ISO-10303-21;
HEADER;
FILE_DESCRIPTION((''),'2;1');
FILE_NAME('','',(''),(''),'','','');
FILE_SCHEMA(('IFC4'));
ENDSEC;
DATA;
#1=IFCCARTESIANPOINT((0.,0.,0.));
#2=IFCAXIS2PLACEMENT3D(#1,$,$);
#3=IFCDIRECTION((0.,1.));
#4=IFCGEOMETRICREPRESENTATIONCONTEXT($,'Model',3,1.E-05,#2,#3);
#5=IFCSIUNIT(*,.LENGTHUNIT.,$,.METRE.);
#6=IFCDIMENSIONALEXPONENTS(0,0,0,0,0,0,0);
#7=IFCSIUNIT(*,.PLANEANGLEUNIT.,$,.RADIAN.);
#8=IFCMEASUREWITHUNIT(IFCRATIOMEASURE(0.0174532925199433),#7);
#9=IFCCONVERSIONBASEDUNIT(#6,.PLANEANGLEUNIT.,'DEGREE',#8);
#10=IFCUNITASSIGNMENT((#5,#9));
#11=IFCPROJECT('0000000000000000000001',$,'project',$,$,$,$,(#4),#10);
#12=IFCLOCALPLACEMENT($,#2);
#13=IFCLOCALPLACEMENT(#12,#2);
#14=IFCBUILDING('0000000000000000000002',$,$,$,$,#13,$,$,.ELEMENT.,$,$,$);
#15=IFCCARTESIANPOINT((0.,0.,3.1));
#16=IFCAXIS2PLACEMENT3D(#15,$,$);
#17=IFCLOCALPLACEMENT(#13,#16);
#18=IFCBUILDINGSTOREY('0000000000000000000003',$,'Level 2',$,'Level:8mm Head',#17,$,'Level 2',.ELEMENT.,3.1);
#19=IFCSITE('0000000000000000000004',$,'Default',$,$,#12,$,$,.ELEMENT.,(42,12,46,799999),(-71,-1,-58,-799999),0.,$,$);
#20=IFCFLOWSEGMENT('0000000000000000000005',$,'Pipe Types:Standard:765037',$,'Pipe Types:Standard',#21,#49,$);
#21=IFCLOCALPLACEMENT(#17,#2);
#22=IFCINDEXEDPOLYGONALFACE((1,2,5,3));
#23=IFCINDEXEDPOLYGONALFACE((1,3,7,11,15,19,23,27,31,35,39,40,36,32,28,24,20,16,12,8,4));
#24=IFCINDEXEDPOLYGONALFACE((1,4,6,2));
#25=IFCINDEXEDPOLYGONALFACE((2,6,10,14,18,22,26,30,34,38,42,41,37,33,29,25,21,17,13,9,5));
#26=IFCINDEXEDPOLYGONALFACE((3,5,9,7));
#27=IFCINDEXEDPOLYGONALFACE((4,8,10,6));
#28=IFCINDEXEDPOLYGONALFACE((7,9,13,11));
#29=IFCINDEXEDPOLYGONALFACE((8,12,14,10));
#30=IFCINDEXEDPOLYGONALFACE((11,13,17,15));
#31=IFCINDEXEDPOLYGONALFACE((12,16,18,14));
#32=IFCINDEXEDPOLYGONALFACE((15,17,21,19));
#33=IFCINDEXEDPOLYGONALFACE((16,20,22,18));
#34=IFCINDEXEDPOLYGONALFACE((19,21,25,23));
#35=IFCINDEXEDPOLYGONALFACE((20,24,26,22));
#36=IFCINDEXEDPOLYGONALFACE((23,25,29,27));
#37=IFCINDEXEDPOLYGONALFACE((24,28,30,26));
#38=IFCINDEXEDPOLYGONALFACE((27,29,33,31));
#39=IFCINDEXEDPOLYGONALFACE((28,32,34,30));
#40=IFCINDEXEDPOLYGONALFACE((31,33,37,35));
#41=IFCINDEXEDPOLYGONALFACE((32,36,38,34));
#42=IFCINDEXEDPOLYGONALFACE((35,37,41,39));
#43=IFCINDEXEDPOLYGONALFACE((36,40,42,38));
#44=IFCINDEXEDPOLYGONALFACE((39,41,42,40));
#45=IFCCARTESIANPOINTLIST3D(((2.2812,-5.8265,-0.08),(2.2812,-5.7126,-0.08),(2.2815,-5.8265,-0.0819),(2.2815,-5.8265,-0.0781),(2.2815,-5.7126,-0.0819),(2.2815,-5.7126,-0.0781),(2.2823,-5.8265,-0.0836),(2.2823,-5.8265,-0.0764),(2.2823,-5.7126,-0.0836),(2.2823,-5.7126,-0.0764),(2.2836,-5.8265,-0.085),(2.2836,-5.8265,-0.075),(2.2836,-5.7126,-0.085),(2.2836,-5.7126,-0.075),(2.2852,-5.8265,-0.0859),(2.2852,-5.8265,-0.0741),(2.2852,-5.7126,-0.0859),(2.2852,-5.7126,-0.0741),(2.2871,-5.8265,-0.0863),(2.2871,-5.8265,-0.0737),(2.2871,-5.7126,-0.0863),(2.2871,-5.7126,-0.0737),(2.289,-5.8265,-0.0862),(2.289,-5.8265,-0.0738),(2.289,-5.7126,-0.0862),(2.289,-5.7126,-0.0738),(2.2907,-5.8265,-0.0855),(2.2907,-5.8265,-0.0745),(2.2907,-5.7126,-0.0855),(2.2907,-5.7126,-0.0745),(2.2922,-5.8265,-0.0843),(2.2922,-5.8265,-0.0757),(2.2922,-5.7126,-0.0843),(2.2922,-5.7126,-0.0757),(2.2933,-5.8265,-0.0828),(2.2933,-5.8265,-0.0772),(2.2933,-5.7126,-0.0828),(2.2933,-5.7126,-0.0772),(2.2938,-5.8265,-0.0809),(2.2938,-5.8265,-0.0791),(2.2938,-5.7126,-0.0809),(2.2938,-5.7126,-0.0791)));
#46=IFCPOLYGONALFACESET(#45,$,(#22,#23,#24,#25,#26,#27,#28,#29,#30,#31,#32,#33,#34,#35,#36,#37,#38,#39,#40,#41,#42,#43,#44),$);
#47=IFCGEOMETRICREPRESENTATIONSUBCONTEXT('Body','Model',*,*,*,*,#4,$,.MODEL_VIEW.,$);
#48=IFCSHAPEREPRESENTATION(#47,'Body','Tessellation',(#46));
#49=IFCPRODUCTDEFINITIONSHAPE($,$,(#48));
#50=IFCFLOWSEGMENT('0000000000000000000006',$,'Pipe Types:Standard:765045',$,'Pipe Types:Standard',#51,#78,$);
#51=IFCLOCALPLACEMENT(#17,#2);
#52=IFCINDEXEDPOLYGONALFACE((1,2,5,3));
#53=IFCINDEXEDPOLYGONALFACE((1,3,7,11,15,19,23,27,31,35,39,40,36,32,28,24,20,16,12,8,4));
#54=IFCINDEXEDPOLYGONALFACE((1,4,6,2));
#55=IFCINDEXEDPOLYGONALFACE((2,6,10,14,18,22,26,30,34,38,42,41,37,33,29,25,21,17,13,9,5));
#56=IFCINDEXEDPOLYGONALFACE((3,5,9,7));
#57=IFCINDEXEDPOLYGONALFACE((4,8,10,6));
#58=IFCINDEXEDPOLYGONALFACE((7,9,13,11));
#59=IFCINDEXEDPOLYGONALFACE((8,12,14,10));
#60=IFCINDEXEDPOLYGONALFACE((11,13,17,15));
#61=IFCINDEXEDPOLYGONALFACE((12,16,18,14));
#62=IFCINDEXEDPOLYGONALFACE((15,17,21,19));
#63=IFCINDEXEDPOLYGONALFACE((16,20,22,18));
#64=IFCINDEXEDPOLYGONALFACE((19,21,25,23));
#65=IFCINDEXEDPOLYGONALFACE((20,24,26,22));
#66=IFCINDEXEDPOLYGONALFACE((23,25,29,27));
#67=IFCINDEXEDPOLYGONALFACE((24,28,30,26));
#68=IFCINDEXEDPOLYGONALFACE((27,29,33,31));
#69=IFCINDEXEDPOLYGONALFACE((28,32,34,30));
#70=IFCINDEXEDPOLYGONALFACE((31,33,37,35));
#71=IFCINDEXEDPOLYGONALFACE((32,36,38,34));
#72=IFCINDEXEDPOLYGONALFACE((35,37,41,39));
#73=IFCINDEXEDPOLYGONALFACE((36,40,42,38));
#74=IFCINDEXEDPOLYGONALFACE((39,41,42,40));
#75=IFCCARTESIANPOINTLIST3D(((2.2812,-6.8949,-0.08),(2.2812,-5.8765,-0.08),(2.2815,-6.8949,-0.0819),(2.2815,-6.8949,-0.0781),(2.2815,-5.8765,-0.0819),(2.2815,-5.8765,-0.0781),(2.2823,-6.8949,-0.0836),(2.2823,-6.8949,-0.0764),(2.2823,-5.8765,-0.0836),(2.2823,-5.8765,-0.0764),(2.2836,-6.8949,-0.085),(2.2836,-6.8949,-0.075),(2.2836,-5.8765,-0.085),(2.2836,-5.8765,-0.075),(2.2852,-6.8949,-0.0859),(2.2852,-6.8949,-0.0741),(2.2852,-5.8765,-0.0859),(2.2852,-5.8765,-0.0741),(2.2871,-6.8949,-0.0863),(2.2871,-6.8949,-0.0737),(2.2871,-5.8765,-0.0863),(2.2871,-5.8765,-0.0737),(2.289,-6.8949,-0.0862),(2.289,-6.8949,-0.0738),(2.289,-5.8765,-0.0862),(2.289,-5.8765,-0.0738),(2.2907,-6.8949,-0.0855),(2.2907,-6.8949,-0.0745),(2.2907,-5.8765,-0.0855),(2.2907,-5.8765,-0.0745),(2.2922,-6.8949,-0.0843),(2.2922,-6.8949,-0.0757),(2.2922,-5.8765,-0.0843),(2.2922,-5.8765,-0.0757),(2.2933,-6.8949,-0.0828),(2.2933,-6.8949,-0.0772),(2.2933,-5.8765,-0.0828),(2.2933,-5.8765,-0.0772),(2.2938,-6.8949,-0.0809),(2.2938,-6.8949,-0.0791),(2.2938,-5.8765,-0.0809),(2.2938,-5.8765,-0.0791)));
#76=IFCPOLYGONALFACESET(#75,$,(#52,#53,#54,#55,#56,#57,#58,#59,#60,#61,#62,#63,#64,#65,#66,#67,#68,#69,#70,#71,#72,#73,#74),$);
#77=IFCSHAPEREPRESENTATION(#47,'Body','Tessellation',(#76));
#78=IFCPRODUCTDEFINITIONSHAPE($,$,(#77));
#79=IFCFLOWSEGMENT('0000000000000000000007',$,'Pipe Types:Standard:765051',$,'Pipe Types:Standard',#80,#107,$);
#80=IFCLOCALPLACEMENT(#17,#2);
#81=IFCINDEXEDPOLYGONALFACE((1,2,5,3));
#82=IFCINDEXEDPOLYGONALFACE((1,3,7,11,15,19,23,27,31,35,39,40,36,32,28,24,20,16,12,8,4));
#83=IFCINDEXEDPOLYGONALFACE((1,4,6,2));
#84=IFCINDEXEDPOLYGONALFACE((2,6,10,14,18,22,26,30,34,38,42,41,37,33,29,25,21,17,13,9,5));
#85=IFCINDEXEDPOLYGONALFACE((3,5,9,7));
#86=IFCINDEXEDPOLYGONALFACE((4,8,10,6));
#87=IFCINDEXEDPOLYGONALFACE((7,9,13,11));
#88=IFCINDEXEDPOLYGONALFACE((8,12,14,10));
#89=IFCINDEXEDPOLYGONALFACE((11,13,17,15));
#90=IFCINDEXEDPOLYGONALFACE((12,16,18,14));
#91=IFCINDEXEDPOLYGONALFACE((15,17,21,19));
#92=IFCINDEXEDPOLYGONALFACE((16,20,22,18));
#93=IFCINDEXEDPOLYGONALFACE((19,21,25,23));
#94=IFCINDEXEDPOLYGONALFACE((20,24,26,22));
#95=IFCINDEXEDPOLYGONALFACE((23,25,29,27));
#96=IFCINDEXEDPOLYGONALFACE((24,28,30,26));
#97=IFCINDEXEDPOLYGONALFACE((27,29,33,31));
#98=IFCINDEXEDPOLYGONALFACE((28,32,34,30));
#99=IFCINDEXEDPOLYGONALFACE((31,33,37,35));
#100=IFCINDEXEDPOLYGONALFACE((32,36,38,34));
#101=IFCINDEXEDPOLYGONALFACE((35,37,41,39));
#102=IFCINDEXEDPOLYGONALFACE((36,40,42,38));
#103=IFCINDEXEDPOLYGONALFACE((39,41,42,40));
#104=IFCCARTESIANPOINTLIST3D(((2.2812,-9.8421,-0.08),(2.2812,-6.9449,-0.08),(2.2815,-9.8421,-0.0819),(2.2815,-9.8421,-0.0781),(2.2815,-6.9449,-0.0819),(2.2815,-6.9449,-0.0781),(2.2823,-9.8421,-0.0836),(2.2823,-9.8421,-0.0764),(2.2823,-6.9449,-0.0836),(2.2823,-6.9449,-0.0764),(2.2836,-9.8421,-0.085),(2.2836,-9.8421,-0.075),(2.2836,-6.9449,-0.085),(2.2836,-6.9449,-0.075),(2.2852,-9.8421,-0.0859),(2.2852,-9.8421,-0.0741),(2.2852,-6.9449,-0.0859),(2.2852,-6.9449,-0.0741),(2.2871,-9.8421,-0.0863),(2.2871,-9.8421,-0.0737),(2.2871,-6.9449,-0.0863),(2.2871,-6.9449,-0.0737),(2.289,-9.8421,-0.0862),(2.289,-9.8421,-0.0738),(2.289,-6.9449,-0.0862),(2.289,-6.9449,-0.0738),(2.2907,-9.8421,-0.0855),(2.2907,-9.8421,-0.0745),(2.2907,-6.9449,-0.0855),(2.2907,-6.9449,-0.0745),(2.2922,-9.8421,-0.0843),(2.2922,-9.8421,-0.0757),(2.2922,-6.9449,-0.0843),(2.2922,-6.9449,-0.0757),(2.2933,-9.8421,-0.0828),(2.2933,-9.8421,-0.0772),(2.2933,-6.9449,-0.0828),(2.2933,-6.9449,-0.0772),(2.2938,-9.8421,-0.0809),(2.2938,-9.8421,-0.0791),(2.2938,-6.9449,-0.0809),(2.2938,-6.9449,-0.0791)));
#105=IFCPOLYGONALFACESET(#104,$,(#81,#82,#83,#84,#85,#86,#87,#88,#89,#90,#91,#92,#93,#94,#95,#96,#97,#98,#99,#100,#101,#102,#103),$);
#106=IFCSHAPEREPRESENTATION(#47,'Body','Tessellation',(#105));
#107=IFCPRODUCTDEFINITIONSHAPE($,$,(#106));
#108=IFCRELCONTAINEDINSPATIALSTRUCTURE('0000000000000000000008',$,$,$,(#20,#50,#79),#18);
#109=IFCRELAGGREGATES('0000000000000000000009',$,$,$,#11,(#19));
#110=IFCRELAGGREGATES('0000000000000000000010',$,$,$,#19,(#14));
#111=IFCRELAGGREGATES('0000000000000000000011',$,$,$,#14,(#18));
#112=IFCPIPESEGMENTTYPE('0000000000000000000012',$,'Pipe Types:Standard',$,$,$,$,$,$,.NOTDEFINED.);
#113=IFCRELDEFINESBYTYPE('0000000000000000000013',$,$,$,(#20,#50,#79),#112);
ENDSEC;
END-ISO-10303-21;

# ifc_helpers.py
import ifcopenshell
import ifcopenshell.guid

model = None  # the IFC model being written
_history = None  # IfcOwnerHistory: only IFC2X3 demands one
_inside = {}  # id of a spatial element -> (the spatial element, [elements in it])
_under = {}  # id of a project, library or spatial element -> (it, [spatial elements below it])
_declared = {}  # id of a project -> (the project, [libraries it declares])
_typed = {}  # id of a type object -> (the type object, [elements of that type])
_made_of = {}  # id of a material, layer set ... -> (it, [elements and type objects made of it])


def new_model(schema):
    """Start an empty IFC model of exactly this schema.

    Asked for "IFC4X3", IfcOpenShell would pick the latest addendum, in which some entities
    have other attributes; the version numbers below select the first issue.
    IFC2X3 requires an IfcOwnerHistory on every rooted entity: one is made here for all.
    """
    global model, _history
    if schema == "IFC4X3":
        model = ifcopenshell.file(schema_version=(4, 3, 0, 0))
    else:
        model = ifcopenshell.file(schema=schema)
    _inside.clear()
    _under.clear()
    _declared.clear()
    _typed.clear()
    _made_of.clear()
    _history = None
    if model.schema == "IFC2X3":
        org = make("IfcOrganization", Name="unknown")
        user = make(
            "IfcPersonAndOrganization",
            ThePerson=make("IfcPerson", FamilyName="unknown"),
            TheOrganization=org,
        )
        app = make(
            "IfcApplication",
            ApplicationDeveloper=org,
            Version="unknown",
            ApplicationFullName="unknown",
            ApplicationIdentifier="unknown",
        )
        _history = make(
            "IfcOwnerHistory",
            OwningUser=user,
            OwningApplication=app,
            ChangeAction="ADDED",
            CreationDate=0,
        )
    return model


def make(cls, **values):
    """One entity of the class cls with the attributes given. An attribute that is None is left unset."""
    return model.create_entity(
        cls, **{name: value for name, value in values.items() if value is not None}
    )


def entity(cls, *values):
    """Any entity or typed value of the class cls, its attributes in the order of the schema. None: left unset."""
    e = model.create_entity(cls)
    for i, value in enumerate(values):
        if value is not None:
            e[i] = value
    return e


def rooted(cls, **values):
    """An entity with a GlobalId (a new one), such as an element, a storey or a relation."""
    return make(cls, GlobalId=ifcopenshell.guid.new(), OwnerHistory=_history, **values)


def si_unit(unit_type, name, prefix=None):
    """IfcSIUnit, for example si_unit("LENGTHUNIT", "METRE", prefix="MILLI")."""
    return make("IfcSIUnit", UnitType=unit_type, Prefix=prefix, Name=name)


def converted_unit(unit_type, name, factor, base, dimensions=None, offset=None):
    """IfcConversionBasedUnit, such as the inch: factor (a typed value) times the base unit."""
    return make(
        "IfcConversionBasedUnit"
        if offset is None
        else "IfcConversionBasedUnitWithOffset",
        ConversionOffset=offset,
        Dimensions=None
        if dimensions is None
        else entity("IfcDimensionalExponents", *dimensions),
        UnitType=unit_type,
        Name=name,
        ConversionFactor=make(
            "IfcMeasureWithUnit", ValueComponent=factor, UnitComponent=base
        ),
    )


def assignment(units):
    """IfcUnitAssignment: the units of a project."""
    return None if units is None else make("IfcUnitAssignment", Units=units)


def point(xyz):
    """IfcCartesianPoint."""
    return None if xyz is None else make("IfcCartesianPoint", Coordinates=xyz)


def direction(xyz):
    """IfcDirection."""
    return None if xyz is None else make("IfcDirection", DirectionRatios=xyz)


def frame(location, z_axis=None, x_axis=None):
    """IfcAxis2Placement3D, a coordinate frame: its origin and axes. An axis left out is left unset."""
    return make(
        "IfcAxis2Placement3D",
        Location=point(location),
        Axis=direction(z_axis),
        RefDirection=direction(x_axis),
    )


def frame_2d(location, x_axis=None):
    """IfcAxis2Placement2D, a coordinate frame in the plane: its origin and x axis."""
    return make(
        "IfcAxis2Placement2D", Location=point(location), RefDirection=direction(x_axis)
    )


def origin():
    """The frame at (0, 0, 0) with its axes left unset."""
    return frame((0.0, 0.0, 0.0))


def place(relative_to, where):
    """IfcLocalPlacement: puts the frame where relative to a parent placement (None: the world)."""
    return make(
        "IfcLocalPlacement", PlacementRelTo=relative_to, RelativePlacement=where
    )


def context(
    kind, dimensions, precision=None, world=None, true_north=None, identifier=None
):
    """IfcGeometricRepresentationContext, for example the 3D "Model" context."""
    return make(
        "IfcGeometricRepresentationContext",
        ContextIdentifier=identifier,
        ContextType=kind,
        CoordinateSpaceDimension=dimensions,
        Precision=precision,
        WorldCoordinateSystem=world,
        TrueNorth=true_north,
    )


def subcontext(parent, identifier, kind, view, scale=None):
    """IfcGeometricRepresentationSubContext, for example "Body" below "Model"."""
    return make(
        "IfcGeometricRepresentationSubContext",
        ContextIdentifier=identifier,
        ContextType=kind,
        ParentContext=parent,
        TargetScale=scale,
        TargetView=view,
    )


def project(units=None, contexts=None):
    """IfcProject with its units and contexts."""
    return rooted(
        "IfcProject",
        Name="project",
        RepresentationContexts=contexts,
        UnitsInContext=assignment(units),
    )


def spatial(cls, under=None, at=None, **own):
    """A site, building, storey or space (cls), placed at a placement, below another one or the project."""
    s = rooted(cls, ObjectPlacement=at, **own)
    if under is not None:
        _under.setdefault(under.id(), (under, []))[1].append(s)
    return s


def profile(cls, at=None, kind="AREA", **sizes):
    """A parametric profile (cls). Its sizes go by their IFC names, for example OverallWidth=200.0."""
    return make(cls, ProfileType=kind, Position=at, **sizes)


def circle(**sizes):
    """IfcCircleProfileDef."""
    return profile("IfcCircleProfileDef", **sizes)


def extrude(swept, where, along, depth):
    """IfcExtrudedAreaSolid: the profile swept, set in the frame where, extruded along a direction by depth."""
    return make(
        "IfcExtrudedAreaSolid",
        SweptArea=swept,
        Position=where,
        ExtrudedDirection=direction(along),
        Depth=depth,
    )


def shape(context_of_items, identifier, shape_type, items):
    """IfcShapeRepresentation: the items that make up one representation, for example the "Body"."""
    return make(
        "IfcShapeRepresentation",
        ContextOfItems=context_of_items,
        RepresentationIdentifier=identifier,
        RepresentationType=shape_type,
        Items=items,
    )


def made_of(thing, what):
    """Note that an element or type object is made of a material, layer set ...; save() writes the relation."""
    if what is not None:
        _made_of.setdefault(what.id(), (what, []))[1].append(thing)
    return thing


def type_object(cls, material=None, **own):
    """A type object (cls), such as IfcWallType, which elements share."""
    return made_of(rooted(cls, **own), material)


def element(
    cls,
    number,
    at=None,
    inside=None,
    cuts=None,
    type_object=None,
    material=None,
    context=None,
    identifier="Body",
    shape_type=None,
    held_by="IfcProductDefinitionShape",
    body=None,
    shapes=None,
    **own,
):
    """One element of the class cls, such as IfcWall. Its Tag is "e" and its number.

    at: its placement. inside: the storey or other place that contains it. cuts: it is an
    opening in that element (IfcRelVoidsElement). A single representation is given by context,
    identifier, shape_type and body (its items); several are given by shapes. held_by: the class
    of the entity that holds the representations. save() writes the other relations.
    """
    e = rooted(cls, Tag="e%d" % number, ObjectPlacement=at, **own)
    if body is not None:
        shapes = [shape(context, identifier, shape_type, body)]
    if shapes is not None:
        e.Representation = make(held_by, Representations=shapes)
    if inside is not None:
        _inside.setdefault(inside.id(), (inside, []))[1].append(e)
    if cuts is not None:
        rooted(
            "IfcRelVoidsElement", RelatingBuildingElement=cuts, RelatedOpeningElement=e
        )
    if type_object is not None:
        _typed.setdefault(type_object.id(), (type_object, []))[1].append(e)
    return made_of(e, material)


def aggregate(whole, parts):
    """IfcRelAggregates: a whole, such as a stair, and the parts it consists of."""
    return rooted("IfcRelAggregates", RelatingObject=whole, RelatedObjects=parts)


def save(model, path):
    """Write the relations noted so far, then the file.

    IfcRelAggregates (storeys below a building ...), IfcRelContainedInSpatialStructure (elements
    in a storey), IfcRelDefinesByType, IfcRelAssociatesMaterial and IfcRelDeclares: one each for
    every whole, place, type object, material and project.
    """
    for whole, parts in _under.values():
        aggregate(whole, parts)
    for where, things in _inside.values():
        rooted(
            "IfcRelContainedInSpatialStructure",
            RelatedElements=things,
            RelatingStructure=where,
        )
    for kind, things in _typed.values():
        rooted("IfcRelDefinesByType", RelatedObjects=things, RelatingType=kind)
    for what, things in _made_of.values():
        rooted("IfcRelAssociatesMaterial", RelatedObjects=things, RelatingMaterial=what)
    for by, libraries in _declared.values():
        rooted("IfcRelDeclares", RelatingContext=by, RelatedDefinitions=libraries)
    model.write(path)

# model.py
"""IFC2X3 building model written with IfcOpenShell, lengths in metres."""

from ifc_helpers import new_model, entity, si_unit, converted_unit, direction, frame, frame_2d, origin, place, context, subcontext, project, spatial, circle, extrude, type_object, element, save


model = new_model("IFC2X3")

# Units and contexts
model_context = context("Model", 3, precision=1e-05, world=origin(), true_north=direction((0.0, 1.0)))
body_context = subcontext(model_context, "Body", "Model", "MODEL_VIEW")
ifc_project = project(units=[si_unit("LENGTHUNIT", "METRE"), converted_unit("PLANEANGLEUNIT", "DEGREE", entity("IfcRatioMeasure", 0.0174532925199433), si_unit("PLANEANGLEUNIT", "RADIAN"), dimensions=[0, 0, 0, 0, 0, 0, 0])], contexts=[model_context])

# Site, building, storey
site_placement = place(None, origin())
site = spatial("IfcSite", under=ifc_project, at=site_placement, Name="Default", CompositionType="ELEMENT", RefLatitude=(42, 12, 46, 799999), RefLongitude=(-71, -1, -58, -799999), RefElevation=0.0)
building_placement = place(site_placement, origin())
building = spatial("IfcBuilding", under=site, at=building_placement, CompositionType="ELEMENT")
storey_placement = place(building_placement, frame((0.0, 0.0, 3.1)))
storey = spatial("IfcBuildingStorey", under=building, at=storey_placement, Name="Level 2", ObjectType="Level:8mm Head", LongName="Level 2", CompositionType="ELEMENT", Elevation=3.1)

# Flow segments
pipe_segment_type = type_object("IfcPipeSegmentType", Name="Pipe Types:Standard", PredefinedType="NOTDEFINED")
flow_segment_1_placement = place(storey_placement, origin())
element("IfcFlowSegment", 1, at=flow_segment_1_placement, inside=storey, type_object=pipe_segment_type, Name="Pipe Types:Standard:765037", ObjectType="Pipe Types:Standard", context=body_context, shape_type="SweptSolid", body=[
    extrude(circle(Radius=0.0063, at=frame_2d((0.0, 0.0), x_axis=(1.0, 0.0))), frame((2.2875, -5.8265, -0.08), z_axis=(0.0, 1.0, 0.0), x_axis=(-1.0, 0.0, 0.0)), (0.0, 0.0, 1.0), 0.1139),
])
flow_segment_2_placement = place(storey_placement, origin())
element("IfcFlowSegment", 2, at=flow_segment_2_placement, inside=storey, type_object=pipe_segment_type, Name="Pipe Types:Standard:765045", ObjectType="Pipe Types:Standard", context=body_context, shape_type="SweptSolid", body=[
    extrude(circle(Radius=0.0063, at=frame_2d((0.0, 0.0), x_axis=(1.0, 0.0))), frame((2.2875, -6.8949, -0.08), z_axis=(0.0, 1.0, 0.0), x_axis=(-1.0, 0.0, 0.0)), (0.0, 0.0, 1.0), 1.0184),
])
flow_segment_3_placement = place(storey_placement, origin())
element("IfcFlowSegment", 3, at=flow_segment_3_placement, inside=storey, type_object=pipe_segment_type, Name="Pipe Types:Standard:765051", ObjectType="Pipe Types:Standard", context=body_context, shape_type="SweptSolid", body=[
    extrude(circle(Radius=0.0063, at=frame_2d((0.0, 0.0), x_axis=(1.0, 0.0))), frame((2.2875, -9.8421, -0.08), z_axis=(0.0, 1.0, 0.0), x_axis=(-1.0, 0.0, 0.0)), (0.0, 0.0, 1.0), 2.8971),
])

save(model, "model.ifc")
